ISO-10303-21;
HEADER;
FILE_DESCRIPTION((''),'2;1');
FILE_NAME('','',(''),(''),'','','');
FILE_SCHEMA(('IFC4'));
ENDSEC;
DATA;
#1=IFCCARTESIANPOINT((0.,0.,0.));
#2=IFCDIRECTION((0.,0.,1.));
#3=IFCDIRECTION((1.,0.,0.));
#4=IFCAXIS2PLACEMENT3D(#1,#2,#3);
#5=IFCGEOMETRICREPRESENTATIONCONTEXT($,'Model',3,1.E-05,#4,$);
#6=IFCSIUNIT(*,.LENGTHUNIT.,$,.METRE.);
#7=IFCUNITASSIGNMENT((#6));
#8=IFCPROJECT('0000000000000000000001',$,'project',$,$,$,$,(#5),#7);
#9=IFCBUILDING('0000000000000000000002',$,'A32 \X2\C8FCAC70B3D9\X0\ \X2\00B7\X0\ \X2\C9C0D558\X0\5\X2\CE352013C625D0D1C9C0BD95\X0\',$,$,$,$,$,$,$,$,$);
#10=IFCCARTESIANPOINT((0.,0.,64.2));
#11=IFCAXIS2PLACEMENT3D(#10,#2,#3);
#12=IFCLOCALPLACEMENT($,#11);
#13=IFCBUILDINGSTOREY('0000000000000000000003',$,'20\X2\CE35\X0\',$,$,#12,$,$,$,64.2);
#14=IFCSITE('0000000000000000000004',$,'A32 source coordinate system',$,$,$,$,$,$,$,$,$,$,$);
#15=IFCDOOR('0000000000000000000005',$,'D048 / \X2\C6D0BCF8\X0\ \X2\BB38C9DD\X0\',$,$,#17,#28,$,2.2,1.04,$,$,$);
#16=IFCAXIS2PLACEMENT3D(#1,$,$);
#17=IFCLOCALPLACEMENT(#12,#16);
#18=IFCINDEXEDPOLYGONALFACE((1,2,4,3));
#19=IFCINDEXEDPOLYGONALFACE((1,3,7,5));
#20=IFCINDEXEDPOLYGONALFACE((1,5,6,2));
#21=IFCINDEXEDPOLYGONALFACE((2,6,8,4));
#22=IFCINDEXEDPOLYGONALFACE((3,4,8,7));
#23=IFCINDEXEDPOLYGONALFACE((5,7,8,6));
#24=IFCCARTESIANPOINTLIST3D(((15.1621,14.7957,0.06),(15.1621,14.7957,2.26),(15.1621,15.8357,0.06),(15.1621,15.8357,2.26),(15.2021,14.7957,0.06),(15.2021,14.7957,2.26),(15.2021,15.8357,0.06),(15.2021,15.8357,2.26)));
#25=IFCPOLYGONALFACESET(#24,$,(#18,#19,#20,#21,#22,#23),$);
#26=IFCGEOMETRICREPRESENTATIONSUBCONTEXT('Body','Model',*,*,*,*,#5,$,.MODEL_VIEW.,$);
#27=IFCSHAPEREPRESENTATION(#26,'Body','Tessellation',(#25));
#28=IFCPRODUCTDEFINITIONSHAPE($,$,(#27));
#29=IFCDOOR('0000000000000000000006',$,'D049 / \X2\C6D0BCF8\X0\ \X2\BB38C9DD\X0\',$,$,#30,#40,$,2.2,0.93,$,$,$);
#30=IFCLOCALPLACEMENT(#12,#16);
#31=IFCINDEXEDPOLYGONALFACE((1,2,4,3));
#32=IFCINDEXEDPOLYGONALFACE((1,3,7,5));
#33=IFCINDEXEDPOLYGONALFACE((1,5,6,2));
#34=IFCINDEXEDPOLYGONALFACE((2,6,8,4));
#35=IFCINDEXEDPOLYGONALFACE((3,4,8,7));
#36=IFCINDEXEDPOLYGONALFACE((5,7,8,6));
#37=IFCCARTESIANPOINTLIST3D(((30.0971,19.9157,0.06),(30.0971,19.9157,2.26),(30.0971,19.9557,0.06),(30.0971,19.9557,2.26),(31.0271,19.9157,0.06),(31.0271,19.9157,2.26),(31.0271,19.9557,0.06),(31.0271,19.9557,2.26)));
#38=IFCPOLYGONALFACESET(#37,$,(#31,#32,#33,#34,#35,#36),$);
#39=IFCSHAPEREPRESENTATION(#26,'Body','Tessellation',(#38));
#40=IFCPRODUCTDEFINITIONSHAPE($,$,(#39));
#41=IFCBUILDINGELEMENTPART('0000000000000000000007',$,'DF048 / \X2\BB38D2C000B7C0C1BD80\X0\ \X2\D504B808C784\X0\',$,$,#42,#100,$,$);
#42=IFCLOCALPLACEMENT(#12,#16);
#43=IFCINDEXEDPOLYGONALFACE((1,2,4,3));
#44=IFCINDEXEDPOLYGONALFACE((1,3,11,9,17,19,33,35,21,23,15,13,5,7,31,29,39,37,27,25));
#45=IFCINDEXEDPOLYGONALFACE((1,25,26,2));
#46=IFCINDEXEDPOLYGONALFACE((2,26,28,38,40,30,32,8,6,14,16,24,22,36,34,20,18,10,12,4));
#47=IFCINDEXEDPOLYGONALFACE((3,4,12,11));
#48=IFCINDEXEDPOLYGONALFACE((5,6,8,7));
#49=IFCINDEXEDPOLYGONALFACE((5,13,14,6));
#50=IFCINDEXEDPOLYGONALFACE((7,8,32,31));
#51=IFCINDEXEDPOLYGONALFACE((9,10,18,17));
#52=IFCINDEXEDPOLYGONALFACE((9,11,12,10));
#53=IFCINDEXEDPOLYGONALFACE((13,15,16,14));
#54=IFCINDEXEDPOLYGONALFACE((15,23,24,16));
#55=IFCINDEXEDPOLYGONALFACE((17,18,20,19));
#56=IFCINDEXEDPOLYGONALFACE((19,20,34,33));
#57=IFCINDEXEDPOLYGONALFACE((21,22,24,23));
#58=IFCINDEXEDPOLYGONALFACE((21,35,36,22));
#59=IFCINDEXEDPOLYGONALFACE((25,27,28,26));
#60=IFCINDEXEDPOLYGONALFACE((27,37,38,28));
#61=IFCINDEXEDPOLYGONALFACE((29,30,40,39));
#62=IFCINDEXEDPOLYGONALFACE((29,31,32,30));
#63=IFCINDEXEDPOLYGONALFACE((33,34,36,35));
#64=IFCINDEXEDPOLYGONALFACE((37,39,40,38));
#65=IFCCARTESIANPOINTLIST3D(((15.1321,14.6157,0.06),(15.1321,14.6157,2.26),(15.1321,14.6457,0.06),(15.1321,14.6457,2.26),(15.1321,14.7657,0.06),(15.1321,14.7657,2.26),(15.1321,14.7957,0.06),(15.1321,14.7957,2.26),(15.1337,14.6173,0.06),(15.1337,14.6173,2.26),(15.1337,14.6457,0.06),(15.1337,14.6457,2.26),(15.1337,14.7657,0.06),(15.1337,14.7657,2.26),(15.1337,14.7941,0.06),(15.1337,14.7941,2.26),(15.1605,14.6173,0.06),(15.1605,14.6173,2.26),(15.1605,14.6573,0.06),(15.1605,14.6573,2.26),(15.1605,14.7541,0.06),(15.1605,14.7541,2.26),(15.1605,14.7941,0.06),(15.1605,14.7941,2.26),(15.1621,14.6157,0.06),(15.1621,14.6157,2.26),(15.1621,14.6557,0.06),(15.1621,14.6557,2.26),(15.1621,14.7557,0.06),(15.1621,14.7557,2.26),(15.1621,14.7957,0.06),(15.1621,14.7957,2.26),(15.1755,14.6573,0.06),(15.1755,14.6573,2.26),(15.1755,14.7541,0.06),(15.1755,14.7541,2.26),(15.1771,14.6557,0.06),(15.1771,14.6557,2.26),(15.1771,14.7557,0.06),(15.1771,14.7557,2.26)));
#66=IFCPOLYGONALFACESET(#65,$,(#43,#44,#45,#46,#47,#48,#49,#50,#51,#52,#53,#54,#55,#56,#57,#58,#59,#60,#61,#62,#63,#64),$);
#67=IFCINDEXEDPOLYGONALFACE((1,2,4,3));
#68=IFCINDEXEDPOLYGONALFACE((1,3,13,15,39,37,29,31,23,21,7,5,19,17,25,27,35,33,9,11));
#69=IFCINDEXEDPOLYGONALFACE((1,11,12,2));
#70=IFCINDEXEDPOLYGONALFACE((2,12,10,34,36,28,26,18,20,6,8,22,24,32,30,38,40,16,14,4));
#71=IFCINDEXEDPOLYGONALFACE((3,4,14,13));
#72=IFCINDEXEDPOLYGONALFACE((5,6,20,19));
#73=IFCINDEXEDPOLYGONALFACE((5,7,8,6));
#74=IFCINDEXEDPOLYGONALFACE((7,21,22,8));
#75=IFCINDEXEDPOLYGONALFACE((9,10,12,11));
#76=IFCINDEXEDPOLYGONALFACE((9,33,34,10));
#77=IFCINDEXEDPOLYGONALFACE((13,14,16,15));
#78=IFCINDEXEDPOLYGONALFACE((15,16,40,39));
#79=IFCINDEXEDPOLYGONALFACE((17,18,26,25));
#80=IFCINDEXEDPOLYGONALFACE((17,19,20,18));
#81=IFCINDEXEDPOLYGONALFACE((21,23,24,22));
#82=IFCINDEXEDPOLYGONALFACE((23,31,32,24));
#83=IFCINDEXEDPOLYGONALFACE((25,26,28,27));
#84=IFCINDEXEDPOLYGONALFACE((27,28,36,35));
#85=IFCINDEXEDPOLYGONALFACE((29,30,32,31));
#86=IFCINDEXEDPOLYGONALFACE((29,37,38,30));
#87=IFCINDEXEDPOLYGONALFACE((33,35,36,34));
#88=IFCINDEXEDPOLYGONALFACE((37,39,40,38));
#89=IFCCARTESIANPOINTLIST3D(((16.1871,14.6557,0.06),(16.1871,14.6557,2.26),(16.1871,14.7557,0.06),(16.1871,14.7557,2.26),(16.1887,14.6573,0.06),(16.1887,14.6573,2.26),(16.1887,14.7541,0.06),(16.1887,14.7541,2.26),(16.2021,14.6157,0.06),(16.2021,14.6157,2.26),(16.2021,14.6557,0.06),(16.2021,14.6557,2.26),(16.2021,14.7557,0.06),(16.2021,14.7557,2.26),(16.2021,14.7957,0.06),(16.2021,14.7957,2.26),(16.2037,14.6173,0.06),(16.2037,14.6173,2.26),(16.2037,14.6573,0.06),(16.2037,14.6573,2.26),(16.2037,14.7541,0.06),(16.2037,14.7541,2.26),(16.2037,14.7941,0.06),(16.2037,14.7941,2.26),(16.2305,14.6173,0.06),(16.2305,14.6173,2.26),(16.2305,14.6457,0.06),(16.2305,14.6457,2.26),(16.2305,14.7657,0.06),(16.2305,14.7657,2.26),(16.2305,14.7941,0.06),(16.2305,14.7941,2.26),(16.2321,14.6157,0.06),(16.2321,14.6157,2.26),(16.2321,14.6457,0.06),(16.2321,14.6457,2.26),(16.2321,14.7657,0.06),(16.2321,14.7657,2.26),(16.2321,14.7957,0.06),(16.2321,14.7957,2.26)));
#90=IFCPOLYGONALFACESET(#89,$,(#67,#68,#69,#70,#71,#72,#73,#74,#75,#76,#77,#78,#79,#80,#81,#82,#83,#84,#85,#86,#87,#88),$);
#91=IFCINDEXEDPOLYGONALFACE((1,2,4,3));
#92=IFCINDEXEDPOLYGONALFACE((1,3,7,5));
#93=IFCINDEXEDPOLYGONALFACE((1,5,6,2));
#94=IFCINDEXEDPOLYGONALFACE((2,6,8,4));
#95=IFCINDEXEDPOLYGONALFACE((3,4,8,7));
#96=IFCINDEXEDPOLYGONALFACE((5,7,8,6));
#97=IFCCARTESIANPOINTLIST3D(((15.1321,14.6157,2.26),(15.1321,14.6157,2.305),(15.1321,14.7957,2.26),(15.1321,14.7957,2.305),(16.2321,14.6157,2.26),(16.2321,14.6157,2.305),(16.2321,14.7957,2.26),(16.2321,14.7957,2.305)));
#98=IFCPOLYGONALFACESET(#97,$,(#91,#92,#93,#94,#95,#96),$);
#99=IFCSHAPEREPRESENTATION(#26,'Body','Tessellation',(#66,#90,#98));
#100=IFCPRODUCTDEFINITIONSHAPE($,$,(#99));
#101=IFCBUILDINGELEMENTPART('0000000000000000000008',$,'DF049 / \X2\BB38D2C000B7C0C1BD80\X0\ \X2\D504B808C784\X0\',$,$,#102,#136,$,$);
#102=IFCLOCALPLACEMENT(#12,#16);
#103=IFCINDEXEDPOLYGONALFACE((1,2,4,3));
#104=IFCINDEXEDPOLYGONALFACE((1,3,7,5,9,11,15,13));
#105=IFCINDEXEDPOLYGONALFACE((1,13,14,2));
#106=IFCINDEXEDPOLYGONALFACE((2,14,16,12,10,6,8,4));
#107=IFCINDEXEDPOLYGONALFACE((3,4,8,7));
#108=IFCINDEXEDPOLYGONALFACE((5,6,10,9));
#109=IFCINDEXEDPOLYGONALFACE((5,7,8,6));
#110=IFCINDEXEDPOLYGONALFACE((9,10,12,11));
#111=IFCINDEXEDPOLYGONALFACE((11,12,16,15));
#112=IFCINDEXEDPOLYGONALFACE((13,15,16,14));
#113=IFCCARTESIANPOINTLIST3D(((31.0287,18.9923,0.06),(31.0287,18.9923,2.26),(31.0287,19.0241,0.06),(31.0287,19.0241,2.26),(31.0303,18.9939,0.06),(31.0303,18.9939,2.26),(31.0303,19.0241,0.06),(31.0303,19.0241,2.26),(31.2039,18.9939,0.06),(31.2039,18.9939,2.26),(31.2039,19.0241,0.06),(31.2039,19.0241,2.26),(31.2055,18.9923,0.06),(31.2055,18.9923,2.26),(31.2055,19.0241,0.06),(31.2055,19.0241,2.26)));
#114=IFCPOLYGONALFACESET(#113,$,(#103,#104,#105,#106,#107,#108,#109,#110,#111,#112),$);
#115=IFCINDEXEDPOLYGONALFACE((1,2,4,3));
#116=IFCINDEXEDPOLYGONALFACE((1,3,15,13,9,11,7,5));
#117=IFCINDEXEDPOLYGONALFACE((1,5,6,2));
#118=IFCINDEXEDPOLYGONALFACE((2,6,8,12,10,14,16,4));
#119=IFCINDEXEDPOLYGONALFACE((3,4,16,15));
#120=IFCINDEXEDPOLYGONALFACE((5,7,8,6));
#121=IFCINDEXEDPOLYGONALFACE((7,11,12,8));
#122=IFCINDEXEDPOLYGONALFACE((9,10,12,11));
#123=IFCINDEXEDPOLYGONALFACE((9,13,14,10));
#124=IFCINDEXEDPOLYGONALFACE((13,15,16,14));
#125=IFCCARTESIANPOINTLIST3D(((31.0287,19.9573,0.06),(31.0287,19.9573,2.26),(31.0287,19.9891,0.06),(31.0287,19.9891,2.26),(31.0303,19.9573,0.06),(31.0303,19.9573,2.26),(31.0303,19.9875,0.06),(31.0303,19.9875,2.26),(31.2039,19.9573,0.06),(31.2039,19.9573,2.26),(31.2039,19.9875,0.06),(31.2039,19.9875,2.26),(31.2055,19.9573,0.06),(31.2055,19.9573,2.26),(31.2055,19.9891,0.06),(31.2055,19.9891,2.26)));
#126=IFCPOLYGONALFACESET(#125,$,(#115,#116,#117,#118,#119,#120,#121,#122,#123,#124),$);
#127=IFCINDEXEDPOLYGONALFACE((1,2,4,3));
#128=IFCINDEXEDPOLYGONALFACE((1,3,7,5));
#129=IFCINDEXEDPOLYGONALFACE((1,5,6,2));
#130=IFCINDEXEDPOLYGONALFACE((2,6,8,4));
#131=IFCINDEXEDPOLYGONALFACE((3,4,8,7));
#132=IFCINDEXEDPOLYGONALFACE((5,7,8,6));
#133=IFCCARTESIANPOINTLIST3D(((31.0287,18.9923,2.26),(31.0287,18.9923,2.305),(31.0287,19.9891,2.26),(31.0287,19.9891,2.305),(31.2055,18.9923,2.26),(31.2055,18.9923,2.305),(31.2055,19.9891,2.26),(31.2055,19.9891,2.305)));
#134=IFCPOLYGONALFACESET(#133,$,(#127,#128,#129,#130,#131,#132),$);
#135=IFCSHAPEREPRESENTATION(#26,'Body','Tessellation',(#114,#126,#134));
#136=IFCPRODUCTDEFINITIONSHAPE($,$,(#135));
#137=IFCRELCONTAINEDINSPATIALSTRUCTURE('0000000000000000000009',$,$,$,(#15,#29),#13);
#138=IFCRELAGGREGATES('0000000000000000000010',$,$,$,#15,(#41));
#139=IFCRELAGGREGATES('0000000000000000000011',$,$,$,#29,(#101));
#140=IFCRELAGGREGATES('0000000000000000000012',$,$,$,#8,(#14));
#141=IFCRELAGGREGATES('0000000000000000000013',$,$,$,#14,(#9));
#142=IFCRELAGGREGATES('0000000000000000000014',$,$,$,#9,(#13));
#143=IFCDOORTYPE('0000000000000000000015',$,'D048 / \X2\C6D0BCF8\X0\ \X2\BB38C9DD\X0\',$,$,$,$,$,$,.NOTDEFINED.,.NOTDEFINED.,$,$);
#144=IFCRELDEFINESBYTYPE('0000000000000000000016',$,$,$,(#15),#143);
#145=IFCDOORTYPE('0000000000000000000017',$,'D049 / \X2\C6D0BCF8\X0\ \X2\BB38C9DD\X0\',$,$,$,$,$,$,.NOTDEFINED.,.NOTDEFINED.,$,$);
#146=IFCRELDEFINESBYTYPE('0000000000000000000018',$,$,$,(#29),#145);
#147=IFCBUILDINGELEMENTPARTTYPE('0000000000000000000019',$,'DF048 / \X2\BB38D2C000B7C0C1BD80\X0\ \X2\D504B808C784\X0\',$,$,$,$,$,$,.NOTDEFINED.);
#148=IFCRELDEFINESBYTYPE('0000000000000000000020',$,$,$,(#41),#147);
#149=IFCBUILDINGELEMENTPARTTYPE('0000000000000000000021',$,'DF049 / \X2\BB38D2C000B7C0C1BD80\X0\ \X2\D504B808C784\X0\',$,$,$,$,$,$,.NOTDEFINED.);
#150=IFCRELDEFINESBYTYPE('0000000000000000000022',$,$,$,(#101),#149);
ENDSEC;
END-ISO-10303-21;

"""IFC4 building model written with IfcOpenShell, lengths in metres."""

from ifc_helpers import new_model, si_unit, frame, origin, origin_with_axes, place, context, subcontext, project, spatial, polyline, outline, extrude, source, transform, mapped, type_object, type_shapes, element, aggregate, save


model = new_model("IFC4")

# Units and contexts
model_context = context("Model", 3, precision=1e-05, world=origin_with_axes())
body_context = subcontext(model_context, "Body", "Model", "MODEL_VIEW")
ifc_project = project(units=[si_unit("LENGTHUNIT", "METRE")], contexts=[model_context])

# Site, building, storey
storey_placement = place(None, frame((0.0, 0.0, 64.2), z_axis=(0.0, 0.0, 1.0), x_axis=(1.0, 0.0, 0.0)))
site = spatial("IfcSite", under=ifc_project, Name="A32 source coordinate system")
building = spatial("IfcBuilding", under=site, Name="A32 주거동 · 지하5층–옥탑지붕")
storey = spatial("IfcBuildingStorey", under=building, at=storey_placement, Name="20층", Elevation=64.2)

# Doors
door_type_1 = type_object("IfcDoorType", Name="D048 / 원본 문짝", OperationType="NOTDEFINED", PredefinedType="NOTDEFINED")
shared_shape_1 = source(origin(), body_context, "Body", "SweptSolid", [
    extrude(outline(polyline([(15.2021, 15.8357), (15.2021, 14.7957), (15.1621, 14.7957), (15.1621, 15.8357), (15.2021, 15.8357)])), frame((0.0, 0.0, 0.06)), (0.0, 0.0, 1.0), 2.2),
])
type_shapes(door_type_1, [shared_shape_1])
door_1_placement = place(storey_placement, origin_with_axes())
door_1 = element("IfcDoor", 1, at=door_1_placement, inside=storey, type_object=door_type_1, Name="D048 / 원본 문짝", OverallHeight=2.2, OverallWidth=1.04, context=body_context, shape_type="MappedRepresentation", body=[
    mapped(shared_shape_1, transform((0.0, 0.0, 0.0), scale=1.0)),
])
door_type_2 = type_object("IfcDoorType", Name="D049 / 원본 문짝", OperationType="NOTDEFINED", PredefinedType="NOTDEFINED")
shared_shape_2 = source(origin(), body_context, "Body", "SweptSolid", [
    extrude(outline(polyline([(31.0271, 19.9557), (31.0271, 19.9157), (30.0971, 19.9157), (30.0971, 19.9557), (31.0271, 19.9557)])), frame((0.0, 0.0, 0.06)), (0.0, 0.0, 1.0), 2.2),
])
type_shapes(door_type_2, [shared_shape_2])
door_2_placement = place(storey_placement, origin_with_axes())
door_2 = element("IfcDoor", 2, at=door_2_placement, inside=storey, type_object=door_type_2, Name="D049 / 원본 문짝", OverallHeight=2.2, OverallWidth=0.93, context=body_context, shape_type="MappedRepresentation", body=[
    mapped(shared_shape_2, transform((0.0, 0.0, 0.0), scale=1.0)),
])

# Building element parts
building_element_part_type_1 = type_object("IfcBuildingElementPartType", Name="DF048 / 문틀·상부 프레임", PredefinedType="NOTDEFINED")
shared_shape_3 = source(origin(), body_context, "Body", "SweptSolid", [
    extrude(outline(polyline([(15.1321, 14.7657), (15.1321, 14.7957), (15.1621, 14.7957), (15.1621, 14.7557), (15.1771, 14.7557), (15.1771, 14.6557), (15.1621, 14.6557), (15.1621, 14.6157), (15.1321, 14.6157), (15.1321, 14.6457), (15.1337, 14.6457), (15.1337, 14.6173), (15.1605, 14.6173), (15.1605, 14.6573), (15.1755, 14.6573), (15.1755, 14.7541), (15.1605, 14.7541), (15.1605, 14.7941), (15.1337, 14.7941), (15.1337, 14.7657), (15.1321, 14.7657)])), frame((0.0, 0.0, 0.06)), (0.0, 0.0, 1.0), 2.2),
    extrude(outline(polyline([(16.2305, 14.7941), (16.2037, 14.7941), (16.2037, 14.7541), (16.1887, 14.7541), (16.1887, 14.6573), (16.2037, 14.6573), (16.2037, 14.6173), (16.2305, 14.6173), (16.2305, 14.6457), (16.2321, 14.6457), (16.2321, 14.6157), (16.2021, 14.6157), (16.2021, 14.6557), (16.1871, 14.6557), (16.1871, 14.7557), (16.2021, 14.7557), (16.2021, 14.7957), (16.2321, 14.7957), (16.2321, 14.7657), (16.2305, 14.7657), (16.2305, 14.7941)])), frame((0.0, 0.0, 0.06)), (0.0, 0.0, 1.0), 2.2),
    extrude(outline(polyline([(15.1321, 14.6157), (15.1321, 14.7957), (16.2321, 14.7957), (16.2321, 14.6157), (15.1321, 14.6157)])), frame((0.0, 0.0, 2.26)), (0.0, 0.0, 1.0), 0.045),
])
type_shapes(building_element_part_type_1, [shared_shape_3])
building_element_part_1_placement = place(door_1_placement, origin_with_axes())
building_element_part_1 = element("IfcBuildingElementPart", 3, at=building_element_part_1_placement, type_object=building_element_part_type_1, Name="DF048 / 문틀·상부 프레임", context=body_context, shape_type="MappedRepresentation", body=[
    mapped(shared_shape_3, transform((0.0, 0.0, 0.0), scale=1.0)),
])
aggregate(door_1, [building_element_part_1])
building_element_part_type_2 = type_object("IfcBuildingElementPartType", Name="DF049 / 문틀·상부 프레임", PredefinedType="NOTDEFINED")
shared_shape_4 = source(origin(), body_context, "Body", "SweptSolid", [
    extrude(outline(polyline([(31.0303, 19.0241), (31.0303, 18.9939), (31.2039, 18.9939), (31.2039, 19.0241), (31.2055, 19.0241), (31.2055, 18.9923), (31.0287, 18.9923), (31.0287, 19.0241), (31.0303, 19.0241)])), frame((0.0, 0.0, 0.06)), (0.0, 0.0, 1.0), 2.2),
    extrude(outline(polyline([(31.0287, 19.9891), (31.2055, 19.9891), (31.2055, 19.9573), (31.2039, 19.9573), (31.2039, 19.9875), (31.0303, 19.9875), (31.0303, 19.9573), (31.0287, 19.9573), (31.0287, 19.9891)])), frame((0.0, 0.0, 0.06)), (0.0, 0.0, 1.0), 2.2),
    extrude(outline(polyline([(31.0287, 18.9923), (31.0287, 19.9891), (31.2055, 19.9891), (31.2055, 18.9923), (31.0287, 18.9923)])), frame((0.0, 0.0, 2.26)), (0.0, 0.0, 1.0), 0.045),
])
type_shapes(building_element_part_type_2, [shared_shape_4])
building_element_part_2_placement = place(door_2_placement, origin_with_axes())
building_element_part_2 = element("IfcBuildingElementPart", 4, at=building_element_part_2_placement, type_object=building_element_part_type_2, Name="DF049 / 문틀·상부 프레임", context=body_context, shape_type="MappedRepresentation", body=[
    mapped(shared_shape_4, transform((0.0, 0.0, 0.0), scale=1.0)),
])
aggregate(door_2, [building_element_part_2])

save(model, "model.ifc")
